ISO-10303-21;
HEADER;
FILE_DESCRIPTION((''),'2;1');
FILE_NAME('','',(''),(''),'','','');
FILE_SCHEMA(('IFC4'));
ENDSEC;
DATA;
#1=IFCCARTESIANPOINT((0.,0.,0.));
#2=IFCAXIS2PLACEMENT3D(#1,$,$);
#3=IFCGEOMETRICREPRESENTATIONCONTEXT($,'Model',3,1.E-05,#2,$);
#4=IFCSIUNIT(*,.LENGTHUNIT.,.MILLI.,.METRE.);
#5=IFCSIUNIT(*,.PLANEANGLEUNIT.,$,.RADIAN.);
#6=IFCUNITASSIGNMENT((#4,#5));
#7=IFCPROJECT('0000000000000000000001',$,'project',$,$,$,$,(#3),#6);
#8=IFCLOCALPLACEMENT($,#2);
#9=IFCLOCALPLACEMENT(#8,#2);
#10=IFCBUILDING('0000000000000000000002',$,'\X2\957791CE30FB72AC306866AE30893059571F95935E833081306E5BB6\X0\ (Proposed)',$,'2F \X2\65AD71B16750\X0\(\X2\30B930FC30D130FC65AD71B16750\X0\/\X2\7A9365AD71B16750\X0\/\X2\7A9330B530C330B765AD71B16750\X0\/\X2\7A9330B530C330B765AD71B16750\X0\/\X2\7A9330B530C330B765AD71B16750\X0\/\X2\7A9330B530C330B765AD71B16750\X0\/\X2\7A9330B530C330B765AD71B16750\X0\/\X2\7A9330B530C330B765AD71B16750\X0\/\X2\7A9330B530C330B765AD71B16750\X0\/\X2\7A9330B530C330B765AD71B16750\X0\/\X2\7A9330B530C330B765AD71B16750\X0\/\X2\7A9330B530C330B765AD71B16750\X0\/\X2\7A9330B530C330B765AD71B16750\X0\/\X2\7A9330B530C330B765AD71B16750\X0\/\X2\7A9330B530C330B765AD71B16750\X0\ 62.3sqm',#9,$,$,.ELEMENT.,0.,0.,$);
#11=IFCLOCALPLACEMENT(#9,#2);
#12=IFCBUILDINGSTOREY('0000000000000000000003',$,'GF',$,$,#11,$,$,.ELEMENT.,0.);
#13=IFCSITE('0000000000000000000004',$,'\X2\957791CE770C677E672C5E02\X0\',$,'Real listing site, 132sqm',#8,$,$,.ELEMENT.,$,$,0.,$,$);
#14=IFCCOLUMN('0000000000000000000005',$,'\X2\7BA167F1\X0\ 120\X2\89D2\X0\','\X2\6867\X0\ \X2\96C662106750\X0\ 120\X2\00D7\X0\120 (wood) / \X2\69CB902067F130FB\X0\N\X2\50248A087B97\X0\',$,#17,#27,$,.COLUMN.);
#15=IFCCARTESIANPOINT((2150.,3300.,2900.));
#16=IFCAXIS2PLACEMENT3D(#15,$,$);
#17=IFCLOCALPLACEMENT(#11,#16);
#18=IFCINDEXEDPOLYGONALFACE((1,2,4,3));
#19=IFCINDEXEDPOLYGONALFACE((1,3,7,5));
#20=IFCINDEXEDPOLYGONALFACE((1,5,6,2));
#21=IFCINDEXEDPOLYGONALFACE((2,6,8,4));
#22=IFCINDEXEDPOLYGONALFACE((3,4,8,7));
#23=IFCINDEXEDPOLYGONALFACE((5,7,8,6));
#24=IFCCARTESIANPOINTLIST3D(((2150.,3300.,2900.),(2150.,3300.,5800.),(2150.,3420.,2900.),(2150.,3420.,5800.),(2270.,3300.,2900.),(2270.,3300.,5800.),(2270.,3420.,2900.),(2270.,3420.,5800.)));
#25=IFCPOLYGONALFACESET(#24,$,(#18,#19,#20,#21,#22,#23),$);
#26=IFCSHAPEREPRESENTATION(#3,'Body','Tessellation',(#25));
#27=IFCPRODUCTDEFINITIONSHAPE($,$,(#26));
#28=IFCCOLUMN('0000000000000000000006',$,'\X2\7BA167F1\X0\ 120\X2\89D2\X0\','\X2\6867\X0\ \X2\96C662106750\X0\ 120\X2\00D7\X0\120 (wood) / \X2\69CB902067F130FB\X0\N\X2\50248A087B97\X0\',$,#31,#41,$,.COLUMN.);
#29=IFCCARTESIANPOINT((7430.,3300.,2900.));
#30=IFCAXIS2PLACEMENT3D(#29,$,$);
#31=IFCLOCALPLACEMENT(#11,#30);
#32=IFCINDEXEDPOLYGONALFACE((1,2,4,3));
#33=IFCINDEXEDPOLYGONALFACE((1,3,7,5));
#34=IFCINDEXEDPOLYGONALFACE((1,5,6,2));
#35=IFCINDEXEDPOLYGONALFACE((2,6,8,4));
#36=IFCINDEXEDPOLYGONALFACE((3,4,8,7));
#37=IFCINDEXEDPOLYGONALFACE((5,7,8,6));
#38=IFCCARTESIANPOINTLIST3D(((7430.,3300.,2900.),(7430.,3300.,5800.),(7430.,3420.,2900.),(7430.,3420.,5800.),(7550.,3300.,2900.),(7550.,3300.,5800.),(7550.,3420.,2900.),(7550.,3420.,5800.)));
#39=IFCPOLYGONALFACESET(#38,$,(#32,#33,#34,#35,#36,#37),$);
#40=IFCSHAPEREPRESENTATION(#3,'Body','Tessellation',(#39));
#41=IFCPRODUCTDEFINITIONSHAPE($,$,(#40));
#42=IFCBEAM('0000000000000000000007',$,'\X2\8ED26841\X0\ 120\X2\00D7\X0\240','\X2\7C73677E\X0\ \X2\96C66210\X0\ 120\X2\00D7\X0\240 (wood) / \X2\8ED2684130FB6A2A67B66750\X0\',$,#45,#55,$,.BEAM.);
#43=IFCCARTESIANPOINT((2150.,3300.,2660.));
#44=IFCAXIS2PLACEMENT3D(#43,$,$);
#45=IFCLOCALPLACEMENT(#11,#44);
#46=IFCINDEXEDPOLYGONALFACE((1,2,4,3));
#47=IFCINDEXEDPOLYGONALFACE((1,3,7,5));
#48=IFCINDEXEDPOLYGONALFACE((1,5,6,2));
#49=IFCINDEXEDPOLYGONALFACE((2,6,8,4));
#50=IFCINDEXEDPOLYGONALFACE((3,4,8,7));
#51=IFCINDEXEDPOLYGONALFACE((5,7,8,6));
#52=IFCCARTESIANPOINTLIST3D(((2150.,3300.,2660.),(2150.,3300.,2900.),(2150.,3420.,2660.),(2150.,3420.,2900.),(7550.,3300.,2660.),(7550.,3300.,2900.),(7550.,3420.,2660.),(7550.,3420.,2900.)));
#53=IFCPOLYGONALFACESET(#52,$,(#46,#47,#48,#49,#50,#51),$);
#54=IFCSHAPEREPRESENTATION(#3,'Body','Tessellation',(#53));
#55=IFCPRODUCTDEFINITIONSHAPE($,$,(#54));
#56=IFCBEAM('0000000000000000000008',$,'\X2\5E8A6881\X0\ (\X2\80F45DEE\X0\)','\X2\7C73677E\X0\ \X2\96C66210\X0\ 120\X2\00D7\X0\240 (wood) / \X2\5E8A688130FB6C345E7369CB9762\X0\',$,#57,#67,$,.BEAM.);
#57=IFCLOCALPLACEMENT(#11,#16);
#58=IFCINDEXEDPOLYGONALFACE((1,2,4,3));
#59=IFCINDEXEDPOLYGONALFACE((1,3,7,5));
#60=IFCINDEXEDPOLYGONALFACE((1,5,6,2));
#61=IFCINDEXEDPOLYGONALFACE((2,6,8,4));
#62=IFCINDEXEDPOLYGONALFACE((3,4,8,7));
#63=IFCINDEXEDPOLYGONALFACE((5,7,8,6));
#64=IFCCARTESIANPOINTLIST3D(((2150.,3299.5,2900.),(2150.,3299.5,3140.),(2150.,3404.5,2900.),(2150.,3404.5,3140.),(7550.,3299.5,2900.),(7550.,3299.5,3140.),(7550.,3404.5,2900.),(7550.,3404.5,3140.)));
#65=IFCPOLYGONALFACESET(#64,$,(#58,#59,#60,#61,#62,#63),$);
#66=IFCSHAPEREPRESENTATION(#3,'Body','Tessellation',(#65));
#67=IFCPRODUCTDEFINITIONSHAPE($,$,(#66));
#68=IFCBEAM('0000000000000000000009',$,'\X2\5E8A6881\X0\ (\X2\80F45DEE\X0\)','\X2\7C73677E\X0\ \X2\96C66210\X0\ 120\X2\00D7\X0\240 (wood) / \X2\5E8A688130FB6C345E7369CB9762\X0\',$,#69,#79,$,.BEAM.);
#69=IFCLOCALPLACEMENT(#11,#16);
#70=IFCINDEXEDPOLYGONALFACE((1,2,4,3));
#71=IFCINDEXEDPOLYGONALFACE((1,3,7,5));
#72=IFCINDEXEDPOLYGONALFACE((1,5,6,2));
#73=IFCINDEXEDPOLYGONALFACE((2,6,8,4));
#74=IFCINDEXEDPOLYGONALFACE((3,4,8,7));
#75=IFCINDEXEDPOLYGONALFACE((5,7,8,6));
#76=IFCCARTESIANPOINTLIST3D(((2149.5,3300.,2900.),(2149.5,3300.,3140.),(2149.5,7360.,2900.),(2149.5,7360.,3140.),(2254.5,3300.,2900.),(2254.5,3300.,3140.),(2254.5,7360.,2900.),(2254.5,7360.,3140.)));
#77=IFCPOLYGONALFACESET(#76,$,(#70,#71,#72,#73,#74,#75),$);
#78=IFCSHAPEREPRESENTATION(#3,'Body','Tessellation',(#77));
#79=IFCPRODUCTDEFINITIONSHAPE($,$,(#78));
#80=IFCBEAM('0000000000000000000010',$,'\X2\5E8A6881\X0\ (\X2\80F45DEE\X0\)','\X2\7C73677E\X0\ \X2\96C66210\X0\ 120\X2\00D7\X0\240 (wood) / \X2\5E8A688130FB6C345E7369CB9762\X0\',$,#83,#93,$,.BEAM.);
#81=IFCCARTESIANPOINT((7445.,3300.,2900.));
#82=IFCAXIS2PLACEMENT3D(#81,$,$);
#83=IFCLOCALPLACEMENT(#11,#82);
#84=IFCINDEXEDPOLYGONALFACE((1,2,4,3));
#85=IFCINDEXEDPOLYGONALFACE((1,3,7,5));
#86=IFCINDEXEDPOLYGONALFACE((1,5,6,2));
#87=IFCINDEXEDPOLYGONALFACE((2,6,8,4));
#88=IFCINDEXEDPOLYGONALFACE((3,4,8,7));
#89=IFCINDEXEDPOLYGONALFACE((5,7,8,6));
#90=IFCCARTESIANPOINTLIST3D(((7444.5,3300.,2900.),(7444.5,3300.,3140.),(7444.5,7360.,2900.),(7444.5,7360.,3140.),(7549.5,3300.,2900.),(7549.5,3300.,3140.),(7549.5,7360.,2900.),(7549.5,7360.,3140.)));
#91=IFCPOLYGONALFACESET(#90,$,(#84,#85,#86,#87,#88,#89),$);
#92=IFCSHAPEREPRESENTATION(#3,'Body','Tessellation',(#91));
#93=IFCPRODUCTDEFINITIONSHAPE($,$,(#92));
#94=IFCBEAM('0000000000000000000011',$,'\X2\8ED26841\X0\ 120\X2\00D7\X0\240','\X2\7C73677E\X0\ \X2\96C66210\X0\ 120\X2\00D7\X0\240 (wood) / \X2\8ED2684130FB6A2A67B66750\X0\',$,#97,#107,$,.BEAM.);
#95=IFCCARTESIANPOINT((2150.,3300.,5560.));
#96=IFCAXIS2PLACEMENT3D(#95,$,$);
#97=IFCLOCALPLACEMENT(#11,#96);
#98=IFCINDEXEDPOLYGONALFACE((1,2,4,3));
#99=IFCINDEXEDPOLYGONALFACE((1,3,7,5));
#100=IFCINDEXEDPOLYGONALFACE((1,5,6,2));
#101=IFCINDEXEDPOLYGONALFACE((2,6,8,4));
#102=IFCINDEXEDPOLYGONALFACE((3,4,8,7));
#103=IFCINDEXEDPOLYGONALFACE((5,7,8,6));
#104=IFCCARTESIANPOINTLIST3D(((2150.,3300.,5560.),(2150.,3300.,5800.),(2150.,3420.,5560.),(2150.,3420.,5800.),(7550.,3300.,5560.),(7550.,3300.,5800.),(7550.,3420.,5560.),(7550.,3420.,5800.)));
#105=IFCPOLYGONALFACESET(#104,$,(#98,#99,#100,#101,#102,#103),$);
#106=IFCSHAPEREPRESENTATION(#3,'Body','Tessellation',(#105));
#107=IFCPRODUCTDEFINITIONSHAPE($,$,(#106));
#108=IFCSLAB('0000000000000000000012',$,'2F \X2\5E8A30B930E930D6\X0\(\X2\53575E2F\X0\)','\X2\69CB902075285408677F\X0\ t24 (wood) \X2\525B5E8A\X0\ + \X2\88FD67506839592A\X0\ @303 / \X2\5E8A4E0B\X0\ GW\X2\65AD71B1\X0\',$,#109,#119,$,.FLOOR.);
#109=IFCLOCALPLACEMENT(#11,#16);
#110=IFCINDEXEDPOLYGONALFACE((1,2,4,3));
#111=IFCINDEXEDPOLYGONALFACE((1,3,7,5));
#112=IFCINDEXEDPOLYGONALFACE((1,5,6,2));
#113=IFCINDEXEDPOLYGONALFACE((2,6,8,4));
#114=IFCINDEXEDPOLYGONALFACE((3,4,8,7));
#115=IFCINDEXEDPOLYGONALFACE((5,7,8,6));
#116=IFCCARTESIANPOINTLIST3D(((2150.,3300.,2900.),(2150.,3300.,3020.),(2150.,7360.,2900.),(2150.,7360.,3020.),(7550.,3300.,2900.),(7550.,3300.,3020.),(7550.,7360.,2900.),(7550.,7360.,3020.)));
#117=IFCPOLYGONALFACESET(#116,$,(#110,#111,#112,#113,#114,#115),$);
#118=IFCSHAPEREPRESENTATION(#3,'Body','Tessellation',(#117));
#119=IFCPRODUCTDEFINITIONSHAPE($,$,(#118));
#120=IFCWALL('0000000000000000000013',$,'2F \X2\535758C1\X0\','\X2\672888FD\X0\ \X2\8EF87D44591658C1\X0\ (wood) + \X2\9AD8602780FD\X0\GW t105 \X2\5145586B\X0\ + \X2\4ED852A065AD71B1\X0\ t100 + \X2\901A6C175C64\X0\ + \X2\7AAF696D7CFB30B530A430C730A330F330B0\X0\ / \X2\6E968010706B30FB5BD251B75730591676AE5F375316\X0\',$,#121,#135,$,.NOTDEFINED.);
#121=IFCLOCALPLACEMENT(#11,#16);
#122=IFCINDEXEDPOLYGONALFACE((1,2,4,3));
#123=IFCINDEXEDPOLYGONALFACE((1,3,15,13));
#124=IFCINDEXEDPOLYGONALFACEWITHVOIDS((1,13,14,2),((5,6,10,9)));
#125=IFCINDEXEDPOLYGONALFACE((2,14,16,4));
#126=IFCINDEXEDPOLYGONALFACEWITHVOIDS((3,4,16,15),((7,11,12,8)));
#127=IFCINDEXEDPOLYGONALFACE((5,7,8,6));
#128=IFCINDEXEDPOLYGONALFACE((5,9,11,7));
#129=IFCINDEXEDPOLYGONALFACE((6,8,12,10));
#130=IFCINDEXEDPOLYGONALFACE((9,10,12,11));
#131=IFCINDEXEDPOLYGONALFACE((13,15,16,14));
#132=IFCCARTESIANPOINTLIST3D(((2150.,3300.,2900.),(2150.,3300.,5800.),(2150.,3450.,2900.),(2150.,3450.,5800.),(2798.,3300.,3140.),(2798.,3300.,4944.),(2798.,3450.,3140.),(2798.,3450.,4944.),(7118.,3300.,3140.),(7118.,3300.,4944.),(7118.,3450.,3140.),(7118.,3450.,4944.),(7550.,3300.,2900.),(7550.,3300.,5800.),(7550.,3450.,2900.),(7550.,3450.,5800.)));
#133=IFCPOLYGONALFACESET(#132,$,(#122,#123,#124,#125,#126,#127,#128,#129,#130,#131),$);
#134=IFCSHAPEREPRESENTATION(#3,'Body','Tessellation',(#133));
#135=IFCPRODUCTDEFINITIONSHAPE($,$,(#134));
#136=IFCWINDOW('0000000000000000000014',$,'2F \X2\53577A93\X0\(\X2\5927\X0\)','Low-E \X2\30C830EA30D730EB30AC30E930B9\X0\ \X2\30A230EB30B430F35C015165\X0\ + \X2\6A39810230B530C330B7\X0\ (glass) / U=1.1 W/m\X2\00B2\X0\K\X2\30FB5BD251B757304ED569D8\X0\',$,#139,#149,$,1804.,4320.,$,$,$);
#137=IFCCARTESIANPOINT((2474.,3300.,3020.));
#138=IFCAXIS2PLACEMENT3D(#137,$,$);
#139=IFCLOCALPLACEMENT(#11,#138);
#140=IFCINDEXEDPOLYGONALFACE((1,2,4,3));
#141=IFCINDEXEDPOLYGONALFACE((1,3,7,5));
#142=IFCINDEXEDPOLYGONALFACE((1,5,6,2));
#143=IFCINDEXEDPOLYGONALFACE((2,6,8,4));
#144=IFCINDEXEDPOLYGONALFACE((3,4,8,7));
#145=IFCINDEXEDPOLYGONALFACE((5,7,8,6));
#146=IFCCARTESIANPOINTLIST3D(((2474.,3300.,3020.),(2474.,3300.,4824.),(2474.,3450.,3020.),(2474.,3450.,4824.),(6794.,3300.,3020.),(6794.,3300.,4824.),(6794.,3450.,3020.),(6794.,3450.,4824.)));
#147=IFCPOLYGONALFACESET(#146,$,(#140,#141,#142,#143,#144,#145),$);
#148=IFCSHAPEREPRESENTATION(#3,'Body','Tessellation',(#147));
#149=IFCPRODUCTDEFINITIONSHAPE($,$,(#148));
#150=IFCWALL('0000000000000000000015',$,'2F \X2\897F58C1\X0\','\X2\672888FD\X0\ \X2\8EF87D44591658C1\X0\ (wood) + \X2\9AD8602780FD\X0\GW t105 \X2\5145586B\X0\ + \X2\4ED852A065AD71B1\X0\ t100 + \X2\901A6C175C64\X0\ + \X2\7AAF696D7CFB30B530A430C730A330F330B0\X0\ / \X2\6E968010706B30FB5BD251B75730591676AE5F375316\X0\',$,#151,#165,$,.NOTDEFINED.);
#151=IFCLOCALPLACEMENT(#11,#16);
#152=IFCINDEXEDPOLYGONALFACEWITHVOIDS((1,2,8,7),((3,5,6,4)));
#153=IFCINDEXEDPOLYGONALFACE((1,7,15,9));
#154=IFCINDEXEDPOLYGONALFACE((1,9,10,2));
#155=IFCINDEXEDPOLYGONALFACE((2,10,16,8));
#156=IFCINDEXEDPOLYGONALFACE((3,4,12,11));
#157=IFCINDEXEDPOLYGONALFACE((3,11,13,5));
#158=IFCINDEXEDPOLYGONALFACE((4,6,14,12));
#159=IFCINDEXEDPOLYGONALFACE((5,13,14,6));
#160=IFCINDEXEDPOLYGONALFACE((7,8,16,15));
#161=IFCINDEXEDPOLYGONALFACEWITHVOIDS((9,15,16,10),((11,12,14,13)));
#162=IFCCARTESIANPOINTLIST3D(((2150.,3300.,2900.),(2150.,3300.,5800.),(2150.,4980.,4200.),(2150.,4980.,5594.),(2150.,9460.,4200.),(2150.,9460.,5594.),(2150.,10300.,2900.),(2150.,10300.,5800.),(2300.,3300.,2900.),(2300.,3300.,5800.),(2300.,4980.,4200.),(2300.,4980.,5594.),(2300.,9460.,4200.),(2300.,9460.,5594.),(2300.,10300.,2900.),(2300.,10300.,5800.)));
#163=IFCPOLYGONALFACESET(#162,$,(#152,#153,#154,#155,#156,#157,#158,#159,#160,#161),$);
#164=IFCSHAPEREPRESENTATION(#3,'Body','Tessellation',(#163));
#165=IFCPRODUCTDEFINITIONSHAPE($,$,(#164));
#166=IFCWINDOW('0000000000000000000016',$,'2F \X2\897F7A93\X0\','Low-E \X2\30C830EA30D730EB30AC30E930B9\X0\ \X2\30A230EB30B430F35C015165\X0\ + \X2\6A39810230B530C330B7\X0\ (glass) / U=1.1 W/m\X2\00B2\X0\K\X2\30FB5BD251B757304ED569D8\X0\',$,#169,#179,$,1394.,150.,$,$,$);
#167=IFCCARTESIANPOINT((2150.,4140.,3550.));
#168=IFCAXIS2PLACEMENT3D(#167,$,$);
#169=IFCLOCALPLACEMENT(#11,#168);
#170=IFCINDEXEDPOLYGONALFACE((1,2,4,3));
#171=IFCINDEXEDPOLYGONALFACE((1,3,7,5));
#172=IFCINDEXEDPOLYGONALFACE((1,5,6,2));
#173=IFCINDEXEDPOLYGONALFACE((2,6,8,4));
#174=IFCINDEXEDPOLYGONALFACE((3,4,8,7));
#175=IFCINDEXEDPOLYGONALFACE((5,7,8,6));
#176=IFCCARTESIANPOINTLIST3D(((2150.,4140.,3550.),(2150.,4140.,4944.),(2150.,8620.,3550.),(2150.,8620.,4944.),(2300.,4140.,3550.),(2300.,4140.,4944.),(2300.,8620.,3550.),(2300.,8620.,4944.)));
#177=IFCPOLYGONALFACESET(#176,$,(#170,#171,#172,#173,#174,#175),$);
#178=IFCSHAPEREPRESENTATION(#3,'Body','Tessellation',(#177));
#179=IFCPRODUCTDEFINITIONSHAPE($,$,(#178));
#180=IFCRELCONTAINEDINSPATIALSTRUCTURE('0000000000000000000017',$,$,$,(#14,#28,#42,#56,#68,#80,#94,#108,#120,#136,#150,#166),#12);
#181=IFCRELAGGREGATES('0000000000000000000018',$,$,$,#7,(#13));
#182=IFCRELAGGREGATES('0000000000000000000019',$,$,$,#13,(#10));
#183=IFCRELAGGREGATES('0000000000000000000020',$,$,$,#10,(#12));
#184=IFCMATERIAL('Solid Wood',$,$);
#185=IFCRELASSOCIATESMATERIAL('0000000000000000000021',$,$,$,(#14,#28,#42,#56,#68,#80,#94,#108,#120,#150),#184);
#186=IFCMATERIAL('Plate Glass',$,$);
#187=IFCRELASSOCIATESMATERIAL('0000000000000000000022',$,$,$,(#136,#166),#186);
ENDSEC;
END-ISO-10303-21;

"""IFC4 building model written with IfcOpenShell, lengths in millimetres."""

from ifc_helpers import new_model, si_unit, frame, frame_2d, origin, place, context, project, spatial, rectangle, extrude, material, element, fill, save


model = new_model("IFC4")

# Units and contexts
model_context = context("Model", 3, precision=1e-05, world=origin())
ifc_project = project(units=[si_unit("LENGTHUNIT", "METRE", prefix="MILLI"), si_unit("PLANEANGLEUNIT", "RADIAN")], contexts=[model_context])

# Site, building, storey
site_placement = place(None, origin())
site = spatial("IfcSite", under=ifc_project, at=site_placement, Name="長野県松本市", ObjectType="Real listing site, 132sqm", CompositionType="ELEMENT", RefElevation=0.0)
building_placement = place(site_placement, origin())
building = spatial("IfcBuilding", under=site, at=building_placement, Name="長野・犬と暮らす土間広めの家 (Proposed)", ObjectType="2F 断熱材(スーパー断熱材/窓断熱材/窓サッシ断熱材/窓サッシ断熱材/窓サッシ断熱材/窓サッシ断熱材/窓サッシ断熱材/窓サッシ断熱材/窓サッシ断熱材/窓サッシ断熱材/窓サッシ断熱材/窓サッシ断熱材/窓サッシ断熱材/窓サッシ断熱材/窓サッシ断熱材 62.3sqm", CompositionType="ELEMENT", ElevationOfRefHeight=0.0, ElevationOfTerrain=0.0)
storey_placement = place(building_placement, origin())
storey = spatial("IfcBuildingStorey", under=building, at=storey_placement, Name="GF", CompositionType="ELEMENT", Elevation=0.0)

# Columns
ifc_material_1 = material(Name="Solid Wood")
column_1_placement = place(storey_placement, frame((2150.0, 3300.0, 2900.0)))
element("IfcColumn", 1, at=column_1_placement, inside=storey, material=ifc_material_1, Name="管柱 120角", Description="桧 集成材 120×120 (wood) / 構造柱・N値計算", PredefinedType="COLUMN", context=model_context, shape_type="SweptSolid", body=[
    extrude(rectangle(XDim=120.0, YDim=120.0, at=frame_2d((60.0, 60.0))), frame((2150.0, 3300.0, 2900.0)), (0.0, 0.0, 1.0), 2900.0),
])
column_2_placement = place(storey_placement, frame((7430.0, 3300.0, 2900.0)))
element("IfcColumn", 2, at=column_2_placement, inside=storey, material=ifc_material_1, Name="管柱 120角", Description="桧 集成材 120×120 (wood) / 構造柱・N値計算", PredefinedType="COLUMN", context=model_context, shape_type="SweptSolid", body=[
    extrude(rectangle(XDim=120.0, YDim=120.0, at=frame_2d((60.0, 60.0))), frame((7430.0, 3300.0, 2900.0)), (0.0, 0.0, 1.0), 2900.0),
])

# Beams
beam_1_placement = place(storey_placement, frame((2150.0, 3300.0, 2660.0)))
element("IfcBeam", 3, at=beam_1_placement, inside=storey, material=ifc_material_1, Name="軒桁 120×240", Description="米松 集成 120×240 (wood) / 軒桁・横架材", PredefinedType="BEAM", context=model_context, shape_type="SweptSolid", body=[
    extrude(rectangle(XDim=5400.0, YDim=120.0, at=frame_2d((2700.0, 60.0))), frame((2150.0, 3300.0, 2660.0)), (0.0, 0.0, 1.0), 240.0),
])
beam_2_placement = place(storey_placement, frame((2150.0, 3300.0, 2900.0)))
element("IfcBeam", 4, at=beam_2_placement, inside=storey, material=ifc_material_1, Name="床梁 (胴差)", Description="米松 集成 120×240 (wood) / 床梁・水平構面", PredefinedType="BEAM", context=model_context, shape_type="SweptSolid", body=[
    extrude(rectangle(XDim=5400.0, YDim=105.0, at=frame_2d((2700.0, 52.0))), frame((2150.0, 3300.0, 2900.0)), (0.0, 0.0, 1.0), 240.0),
])
beam_3_placement = place(storey_placement, frame((2150.0, 3300.0, 2900.0)))
element("IfcBeam", 5, at=beam_3_placement, inside=storey, material=ifc_material_1, Name="床梁 (胴差)", Description="米松 集成 120×240 (wood) / 床梁・水平構面", PredefinedType="BEAM", context=model_context, shape_type="SweptSolid", body=[
    extrude(rectangle(XDim=105.0, YDim=4060.0, at=frame_2d((52.0, 2030.0))), frame((2150.0, 3300.0, 2900.0)), (0.0, 0.0, 1.0), 240.0),
])
beam_4_placement = place(storey_placement, frame((7445.0, 3300.0, 2900.0)))
element("IfcBeam", 6, at=beam_4_placement, inside=storey, material=ifc_material_1, Name="床梁 (胴差)", Description="米松 集成 120×240 (wood) / 床梁・水平構面", PredefinedType="BEAM", context=model_context, shape_type="SweptSolid", body=[
    extrude(rectangle(XDim=105.0, YDim=4060.0, at=frame_2d((52.0, 2030.0))), frame((7445.0, 3300.0, 2900.0)), (0.0, 0.0, 1.0), 240.0),
])
beam_5_placement = place(storey_placement, frame((2150.0, 3300.0, 5560.0)))
element("IfcBeam", 7, at=beam_5_placement, inside=storey, material=ifc_material_1, Name="軒桁 120×240", Description="米松 集成 120×240 (wood) / 軒桁・横架材", PredefinedType="BEAM", context=model_context, shape_type="SweptSolid", body=[
    extrude(rectangle(XDim=5400.0, YDim=120.0, at=frame_2d((2700.0, 60.0))), frame((2150.0, 3300.0, 5560.0)), (0.0, 0.0, 1.0), 240.0),
])

# Slab
slab_placement = place(storey_placement, frame((2150.0, 3300.0, 2900.0)))
element("IfcSlab", 8, at=slab_placement, inside=storey, material=ifc_material_1, Name="2F 床スラブ(南帯)", Description="構造用合板 t24 (wood) 剛床 + 製材根太 @303 / 床下 GW断熱", PredefinedType="FLOOR", context=model_context, shape_type="SweptSolid", body=[
    extrude(rectangle(XDim=5400.0, YDim=4060.0, at=frame_2d((2700.0, 2030.0))), frame((2150.0, 3300.0, 2900.0)), (0.0, 0.0, 1.0), 120.0),
])

# Walls, openings, windows
wall_1_placement = place(storey_placement, frame((2150.0, 3300.0, 2900.0)))
wall_1 = element("IfcWall", 9, at=wall_1_placement, inside=storey, material=ifc_material_1, Name="2F 南壁", Description="木製 軸組外壁 (wood) + 高性能GW t105 充填 + 付加断熱 t100 + 通気層 + 窯業系サイディング / 準耐火・寒冷地外皮強化", PredefinedType="NOTDEFINED", context=model_context, shape_type="SweptSolid", body=[
    extrude(rectangle(XDim=5400.0, YDim=150.0, at=frame_2d((2700.0, 75.0))), frame((2150.0, 3300.0, 2900.0)), (0.0, 0.0, 1.0), 2900.0),
])
opening_1_placement = place(storey_placement, frame((2474.0, 3300.0, 3020.0)))
opening_1 = element("IfcOpeningElement", 10, at=opening_1_placement, cuts=wall_1, PredefinedType="NOTDEFINED", context=model_context, shape_type="SweptSolid", body=[
    extrude(rectangle(XDim=4320.0, YDim=150.0, at=frame_2d((2160.0, 75.0))), frame((2474.0, 3300.0, 3020.0)), (0.0, 0.0, 1.0), 1804.0),
])
ifc_material_2 = material(Name="Plate Glass")
window_1_placement = place(storey_placement, frame((2474.0, 3300.0, 3020.0)))
window_1 = element("IfcWindow", 11, at=window_1_placement, inside=storey, material=ifc_material_2, Name="2F 南窓(大)", Description="Low-E トリプルガラス アルゴン封入 + 樹脂サッシ (glass) / U=1.1 W/m²K・寒冷地仕様", OverallHeight=1804.0, OverallWidth=4320.0, context=model_context, shape_type="SweptSolid", body=[
    extrude(rectangle(XDim=4320.0, YDim=150.0, at=frame_2d((2160.0, 75.0))), frame((2474.0, 3300.0, 3020.0)), (0.0, 0.0, 1.0), 1804.0),
])
fill(opening_1, window_1)
wall_2_placement = place(storey_placement, frame((2150.0, 3300.0, 2900.0)))
wall_2 = element("IfcWall", 12, at=wall_2_placement, inside=storey, material=ifc_material_1, Name="2F 西壁", Description="木製 軸組外壁 (wood) + 高性能GW t105 充填 + 付加断熱 t100 + 通気層 + 窯業系サイディング / 準耐火・寒冷地外皮強化", PredefinedType="NOTDEFINED", context=model_context, shape_type="SweptSolid", body=[
    extrude(rectangle(XDim=150.0, YDim=7000.0, at=frame_2d((75.0, 3500.0))), frame((2150.0, 3300.0, 2900.0)), (0.0, 0.0, 1.0), 2900.0),
])
opening_2_placement = place(storey_placement, frame((2150.0, 4140.0, 3550.0)))
opening_2 = element("IfcOpeningElement", 13, at=opening_2_placement, cuts=wall_2, PredefinedType="NOTDEFINED", context=model_context, shape_type="SweptSolid", body=[
    extrude(rectangle(XDim=150.0, YDim=4480.0, at=frame_2d((75.0, 2240.0))), frame((2150.0, 4140.0, 3550.0)), (0.0, 0.0, 1.0), 1394.0),
])
window_2_placement = place(storey_placement, frame((2150.0, 4140.0, 3550.0)))
window_2 = element("IfcWindow", 14, at=window_2_placement, inside=storey, material=ifc_material_2, Name="2F 西窓", Description="Low-E トリプルガラス アルゴン封入 + 樹脂サッシ (glass) / U=1.1 W/m²K・寒冷地仕様", OverallHeight=1394.0, OverallWidth=150.0, context=model_context, shape_type="SweptSolid", body=[
    extrude(rectangle(XDim=150.0, YDim=4480.0, at=frame_2d((75.0, 2240.0))), frame((2150.0, 4140.0, 3550.0)), (0.0, 0.0, 1.0), 1394.0),
])
fill(opening_2, window_2)

save(model, "model.ifc")
